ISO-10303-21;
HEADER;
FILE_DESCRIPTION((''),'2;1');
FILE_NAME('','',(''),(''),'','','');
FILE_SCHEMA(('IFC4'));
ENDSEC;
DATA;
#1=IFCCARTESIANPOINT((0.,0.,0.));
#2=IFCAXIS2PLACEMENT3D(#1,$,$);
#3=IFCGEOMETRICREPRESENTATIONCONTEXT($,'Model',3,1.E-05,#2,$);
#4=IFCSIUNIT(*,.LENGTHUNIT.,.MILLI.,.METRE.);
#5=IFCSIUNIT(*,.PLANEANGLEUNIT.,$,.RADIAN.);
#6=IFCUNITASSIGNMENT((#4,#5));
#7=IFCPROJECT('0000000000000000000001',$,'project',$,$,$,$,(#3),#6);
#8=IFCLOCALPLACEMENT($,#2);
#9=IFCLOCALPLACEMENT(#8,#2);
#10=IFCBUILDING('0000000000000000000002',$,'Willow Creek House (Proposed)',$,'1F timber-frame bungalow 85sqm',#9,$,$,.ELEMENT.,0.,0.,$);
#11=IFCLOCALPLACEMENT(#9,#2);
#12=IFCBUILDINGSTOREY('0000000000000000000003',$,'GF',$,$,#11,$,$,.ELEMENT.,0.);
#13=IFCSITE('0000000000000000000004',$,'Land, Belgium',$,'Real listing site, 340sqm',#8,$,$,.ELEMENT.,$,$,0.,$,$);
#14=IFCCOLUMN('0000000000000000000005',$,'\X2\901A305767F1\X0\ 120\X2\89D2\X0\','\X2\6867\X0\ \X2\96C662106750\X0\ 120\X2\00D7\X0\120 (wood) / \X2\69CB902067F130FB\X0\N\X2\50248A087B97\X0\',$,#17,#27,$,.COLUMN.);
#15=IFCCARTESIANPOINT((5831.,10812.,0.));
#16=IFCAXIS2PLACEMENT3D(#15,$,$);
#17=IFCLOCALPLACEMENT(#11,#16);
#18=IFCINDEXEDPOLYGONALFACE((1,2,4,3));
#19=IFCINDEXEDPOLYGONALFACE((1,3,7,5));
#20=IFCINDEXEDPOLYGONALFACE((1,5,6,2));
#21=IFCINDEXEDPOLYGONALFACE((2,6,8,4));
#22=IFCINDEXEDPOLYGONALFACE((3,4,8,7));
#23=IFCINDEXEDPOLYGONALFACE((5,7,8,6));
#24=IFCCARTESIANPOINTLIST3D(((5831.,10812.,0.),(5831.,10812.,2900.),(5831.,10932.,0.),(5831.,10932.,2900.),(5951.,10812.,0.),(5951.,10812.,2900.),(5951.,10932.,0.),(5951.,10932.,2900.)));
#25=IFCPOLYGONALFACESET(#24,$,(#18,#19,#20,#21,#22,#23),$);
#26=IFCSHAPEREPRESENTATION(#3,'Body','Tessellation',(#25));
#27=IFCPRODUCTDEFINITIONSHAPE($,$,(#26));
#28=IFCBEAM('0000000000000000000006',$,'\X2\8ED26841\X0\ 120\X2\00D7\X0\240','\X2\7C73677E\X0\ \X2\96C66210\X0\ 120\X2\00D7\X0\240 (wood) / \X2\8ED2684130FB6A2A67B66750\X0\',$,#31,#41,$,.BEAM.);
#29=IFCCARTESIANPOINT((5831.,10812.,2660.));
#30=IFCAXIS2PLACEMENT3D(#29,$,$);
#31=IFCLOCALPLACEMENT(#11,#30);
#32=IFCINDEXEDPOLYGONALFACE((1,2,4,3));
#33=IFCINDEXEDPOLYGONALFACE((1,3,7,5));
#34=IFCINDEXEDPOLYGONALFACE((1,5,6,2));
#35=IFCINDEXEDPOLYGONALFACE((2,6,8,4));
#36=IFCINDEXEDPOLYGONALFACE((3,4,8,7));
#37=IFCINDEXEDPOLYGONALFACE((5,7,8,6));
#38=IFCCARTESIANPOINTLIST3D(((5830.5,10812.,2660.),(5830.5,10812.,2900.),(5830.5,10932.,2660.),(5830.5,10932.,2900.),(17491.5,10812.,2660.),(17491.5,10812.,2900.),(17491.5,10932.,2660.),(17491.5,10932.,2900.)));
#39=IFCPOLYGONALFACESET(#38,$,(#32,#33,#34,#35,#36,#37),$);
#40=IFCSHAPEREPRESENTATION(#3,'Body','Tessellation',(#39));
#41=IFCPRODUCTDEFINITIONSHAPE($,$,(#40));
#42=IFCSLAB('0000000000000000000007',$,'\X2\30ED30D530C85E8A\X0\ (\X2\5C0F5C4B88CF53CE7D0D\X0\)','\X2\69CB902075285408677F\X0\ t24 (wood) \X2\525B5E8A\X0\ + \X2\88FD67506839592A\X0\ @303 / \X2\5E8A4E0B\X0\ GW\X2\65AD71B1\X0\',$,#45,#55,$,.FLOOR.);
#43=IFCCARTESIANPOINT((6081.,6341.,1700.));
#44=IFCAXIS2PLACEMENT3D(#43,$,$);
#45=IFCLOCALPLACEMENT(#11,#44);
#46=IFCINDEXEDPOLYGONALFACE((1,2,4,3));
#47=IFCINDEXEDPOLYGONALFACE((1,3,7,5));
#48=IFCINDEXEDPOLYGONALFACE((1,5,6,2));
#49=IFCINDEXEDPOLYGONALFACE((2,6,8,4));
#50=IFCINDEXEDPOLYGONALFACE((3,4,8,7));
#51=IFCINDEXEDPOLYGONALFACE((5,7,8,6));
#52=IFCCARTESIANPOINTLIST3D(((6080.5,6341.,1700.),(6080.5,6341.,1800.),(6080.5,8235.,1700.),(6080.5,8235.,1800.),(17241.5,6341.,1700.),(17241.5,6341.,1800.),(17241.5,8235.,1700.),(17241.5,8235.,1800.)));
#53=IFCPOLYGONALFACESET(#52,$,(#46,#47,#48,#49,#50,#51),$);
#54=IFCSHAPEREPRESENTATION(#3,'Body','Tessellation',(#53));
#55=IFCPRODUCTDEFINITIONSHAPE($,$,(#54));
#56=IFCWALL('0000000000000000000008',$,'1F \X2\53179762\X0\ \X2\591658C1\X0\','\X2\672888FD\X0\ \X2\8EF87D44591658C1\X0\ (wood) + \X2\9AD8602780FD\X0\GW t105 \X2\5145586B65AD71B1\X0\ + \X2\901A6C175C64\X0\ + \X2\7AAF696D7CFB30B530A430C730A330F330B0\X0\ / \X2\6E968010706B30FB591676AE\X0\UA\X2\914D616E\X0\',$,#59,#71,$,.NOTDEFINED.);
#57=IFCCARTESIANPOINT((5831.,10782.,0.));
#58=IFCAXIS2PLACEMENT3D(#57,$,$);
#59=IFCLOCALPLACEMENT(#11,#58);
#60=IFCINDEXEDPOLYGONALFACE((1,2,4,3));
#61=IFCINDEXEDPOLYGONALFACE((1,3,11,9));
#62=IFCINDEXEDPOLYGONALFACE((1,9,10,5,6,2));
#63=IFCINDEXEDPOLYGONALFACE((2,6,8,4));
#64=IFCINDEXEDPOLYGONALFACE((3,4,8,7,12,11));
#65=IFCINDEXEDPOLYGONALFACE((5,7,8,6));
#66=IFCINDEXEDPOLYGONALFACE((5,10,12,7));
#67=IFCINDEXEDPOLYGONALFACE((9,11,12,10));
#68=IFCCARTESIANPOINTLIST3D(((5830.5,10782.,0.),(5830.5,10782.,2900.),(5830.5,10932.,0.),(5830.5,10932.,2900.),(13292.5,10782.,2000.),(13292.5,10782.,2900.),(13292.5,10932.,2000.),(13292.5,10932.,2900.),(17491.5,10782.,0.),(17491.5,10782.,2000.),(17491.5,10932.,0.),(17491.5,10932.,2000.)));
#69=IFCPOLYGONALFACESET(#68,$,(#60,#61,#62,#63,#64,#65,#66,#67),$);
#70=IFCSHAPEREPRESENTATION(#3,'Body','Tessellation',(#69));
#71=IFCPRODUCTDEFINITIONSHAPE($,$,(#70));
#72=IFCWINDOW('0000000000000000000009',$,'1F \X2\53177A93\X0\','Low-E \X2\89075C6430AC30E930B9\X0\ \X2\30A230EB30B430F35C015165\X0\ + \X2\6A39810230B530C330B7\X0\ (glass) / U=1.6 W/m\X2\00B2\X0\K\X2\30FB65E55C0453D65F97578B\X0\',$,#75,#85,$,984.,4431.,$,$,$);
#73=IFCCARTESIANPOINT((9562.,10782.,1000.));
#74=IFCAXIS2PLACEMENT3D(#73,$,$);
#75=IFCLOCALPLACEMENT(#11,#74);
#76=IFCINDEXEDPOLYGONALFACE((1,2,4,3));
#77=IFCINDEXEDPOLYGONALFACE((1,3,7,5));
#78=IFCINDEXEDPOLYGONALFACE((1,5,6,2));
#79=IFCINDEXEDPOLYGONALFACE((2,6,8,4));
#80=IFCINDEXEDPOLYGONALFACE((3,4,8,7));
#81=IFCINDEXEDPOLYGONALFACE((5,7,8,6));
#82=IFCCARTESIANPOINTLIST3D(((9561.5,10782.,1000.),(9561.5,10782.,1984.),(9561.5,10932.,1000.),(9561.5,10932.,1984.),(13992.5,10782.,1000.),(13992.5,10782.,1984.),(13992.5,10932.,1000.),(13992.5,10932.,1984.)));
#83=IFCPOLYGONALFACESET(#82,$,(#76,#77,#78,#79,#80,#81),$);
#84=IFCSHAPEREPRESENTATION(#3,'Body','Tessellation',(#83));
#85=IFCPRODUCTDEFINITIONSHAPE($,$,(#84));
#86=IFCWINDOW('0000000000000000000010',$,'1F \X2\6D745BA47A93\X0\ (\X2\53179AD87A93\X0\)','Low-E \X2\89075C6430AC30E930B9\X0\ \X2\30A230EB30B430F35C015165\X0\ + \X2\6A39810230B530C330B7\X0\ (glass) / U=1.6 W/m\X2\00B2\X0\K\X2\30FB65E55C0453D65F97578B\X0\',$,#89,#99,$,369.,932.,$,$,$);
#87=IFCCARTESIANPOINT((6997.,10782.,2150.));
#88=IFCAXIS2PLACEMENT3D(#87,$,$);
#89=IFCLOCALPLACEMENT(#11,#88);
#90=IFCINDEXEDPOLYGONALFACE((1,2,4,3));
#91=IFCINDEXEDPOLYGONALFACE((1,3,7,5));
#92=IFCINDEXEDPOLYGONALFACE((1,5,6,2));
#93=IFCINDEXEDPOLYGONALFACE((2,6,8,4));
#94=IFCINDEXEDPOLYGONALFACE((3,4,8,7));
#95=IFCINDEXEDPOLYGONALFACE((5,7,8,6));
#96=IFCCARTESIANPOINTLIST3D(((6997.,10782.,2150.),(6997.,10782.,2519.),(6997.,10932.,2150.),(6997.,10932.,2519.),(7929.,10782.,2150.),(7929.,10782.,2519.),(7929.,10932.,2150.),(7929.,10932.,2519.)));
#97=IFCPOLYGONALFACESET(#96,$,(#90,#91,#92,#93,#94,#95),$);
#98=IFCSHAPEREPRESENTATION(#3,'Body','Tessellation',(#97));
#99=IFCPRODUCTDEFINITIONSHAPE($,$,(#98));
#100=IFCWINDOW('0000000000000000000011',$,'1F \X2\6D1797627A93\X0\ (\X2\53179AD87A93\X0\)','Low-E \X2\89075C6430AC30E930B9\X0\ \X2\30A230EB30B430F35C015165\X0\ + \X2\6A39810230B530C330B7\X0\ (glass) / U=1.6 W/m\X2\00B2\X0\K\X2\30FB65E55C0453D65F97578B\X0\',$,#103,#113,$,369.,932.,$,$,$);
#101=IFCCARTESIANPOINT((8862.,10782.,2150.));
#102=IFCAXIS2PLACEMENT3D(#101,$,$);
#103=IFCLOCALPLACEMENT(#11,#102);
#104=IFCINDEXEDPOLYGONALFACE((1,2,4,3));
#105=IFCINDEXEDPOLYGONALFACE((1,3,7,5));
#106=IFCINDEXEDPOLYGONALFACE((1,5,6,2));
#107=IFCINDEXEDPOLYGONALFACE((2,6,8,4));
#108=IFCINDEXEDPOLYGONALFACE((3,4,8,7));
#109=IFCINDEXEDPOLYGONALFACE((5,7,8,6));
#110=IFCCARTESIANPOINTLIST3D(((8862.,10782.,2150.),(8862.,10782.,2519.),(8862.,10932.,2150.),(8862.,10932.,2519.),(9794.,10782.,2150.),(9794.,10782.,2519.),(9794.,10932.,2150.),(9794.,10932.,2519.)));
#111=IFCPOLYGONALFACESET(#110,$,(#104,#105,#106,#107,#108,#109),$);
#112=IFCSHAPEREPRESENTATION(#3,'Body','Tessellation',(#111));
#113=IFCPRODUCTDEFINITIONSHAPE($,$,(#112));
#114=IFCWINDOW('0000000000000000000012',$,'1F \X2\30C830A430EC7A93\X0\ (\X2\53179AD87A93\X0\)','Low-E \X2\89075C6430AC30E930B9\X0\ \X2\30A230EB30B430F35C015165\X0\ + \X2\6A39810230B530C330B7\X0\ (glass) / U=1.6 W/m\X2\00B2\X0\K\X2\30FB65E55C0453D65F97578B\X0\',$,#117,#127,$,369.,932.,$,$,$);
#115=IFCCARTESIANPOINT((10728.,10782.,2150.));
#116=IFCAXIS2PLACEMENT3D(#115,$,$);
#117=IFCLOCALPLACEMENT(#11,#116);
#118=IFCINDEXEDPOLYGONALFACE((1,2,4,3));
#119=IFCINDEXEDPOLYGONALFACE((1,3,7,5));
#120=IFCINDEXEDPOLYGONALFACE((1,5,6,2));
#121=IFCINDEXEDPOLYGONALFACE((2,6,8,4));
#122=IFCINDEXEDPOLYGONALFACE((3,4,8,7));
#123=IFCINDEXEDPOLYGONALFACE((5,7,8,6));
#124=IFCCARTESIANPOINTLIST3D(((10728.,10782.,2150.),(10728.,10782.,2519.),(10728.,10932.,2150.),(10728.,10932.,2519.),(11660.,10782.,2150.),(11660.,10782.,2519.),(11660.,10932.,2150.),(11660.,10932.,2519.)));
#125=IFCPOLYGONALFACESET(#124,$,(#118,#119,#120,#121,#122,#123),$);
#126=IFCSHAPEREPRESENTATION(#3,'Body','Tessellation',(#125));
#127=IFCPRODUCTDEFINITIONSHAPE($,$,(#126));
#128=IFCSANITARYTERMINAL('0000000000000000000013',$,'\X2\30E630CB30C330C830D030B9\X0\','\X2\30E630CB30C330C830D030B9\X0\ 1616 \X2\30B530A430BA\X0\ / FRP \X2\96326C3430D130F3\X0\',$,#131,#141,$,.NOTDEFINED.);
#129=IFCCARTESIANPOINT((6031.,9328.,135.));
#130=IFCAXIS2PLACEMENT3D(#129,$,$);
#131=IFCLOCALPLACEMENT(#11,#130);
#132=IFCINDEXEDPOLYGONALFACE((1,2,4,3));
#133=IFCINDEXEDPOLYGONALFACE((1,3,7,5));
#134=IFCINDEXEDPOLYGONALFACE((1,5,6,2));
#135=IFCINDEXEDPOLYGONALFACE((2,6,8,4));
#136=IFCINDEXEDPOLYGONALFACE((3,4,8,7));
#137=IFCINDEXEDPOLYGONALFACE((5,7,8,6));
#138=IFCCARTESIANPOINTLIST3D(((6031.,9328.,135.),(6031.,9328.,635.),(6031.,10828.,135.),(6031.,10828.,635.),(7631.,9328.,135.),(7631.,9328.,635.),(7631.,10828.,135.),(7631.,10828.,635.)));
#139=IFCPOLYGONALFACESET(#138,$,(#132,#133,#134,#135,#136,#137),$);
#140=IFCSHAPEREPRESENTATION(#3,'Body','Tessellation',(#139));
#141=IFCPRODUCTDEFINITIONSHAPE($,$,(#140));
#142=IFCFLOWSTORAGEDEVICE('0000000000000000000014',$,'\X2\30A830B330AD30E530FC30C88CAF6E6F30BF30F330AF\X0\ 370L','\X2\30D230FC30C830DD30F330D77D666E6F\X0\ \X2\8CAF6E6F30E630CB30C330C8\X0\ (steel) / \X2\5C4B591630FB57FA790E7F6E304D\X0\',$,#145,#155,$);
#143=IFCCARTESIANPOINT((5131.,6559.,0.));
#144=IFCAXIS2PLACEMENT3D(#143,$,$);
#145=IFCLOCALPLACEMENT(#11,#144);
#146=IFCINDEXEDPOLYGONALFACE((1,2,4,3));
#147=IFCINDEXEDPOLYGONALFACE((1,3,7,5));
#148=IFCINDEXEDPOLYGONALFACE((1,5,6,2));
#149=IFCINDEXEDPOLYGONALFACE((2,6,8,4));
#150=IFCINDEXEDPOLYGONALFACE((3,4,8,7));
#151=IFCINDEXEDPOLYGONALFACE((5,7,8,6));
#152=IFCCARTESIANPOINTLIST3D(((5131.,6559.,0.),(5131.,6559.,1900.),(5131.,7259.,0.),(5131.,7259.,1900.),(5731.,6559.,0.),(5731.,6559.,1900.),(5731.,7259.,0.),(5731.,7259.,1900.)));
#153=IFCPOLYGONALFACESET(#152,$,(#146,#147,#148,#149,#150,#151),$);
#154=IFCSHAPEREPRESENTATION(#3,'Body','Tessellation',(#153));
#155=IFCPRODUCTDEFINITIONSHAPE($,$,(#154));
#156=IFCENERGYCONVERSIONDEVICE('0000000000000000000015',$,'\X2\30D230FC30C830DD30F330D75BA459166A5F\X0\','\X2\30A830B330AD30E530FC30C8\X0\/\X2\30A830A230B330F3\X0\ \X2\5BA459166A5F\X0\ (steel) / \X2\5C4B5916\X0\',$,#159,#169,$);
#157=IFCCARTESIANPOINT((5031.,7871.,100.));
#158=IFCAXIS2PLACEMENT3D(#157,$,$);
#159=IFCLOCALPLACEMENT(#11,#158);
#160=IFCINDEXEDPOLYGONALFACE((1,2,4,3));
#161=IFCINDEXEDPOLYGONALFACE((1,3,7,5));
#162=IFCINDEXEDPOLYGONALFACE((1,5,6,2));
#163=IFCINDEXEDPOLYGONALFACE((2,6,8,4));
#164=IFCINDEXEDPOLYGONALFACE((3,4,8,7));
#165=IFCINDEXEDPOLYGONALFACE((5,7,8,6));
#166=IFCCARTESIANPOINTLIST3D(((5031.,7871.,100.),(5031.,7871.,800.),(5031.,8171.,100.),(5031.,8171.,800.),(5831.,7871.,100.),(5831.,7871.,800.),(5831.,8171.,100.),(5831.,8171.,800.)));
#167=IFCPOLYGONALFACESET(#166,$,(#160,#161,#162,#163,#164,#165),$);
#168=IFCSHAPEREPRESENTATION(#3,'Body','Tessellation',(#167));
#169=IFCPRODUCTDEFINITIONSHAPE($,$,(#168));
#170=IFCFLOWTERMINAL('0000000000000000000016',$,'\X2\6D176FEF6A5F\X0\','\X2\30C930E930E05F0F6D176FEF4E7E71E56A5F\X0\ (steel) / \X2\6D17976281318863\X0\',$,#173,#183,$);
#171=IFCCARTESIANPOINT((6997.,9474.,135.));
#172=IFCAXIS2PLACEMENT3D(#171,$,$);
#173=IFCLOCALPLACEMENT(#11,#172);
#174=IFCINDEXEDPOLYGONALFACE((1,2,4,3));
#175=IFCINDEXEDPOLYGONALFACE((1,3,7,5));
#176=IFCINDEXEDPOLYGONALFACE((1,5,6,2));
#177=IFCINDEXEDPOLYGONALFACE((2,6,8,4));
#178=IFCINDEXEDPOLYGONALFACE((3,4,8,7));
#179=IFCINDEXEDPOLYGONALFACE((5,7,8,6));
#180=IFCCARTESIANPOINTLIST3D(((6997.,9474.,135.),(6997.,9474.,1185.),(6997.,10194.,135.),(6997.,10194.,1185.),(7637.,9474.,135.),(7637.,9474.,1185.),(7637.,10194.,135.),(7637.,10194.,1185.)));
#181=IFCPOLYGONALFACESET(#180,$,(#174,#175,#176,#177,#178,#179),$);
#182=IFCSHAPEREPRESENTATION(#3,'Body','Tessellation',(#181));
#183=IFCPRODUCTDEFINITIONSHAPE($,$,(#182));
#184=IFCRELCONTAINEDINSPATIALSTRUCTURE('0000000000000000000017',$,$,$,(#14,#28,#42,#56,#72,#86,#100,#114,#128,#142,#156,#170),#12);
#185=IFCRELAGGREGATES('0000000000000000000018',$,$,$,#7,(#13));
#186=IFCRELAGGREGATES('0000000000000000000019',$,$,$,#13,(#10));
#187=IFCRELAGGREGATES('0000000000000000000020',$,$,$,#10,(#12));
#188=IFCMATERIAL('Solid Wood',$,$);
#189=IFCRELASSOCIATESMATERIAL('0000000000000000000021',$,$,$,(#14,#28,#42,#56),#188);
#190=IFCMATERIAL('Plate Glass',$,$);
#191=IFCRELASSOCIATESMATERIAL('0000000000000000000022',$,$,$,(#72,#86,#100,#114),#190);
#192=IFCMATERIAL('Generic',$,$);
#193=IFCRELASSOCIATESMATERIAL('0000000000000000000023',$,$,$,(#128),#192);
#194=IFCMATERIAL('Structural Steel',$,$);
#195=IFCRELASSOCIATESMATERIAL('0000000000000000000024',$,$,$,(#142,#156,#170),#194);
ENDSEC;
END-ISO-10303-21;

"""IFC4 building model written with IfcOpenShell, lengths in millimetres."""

from ifc_helpers import new_model, si_unit, frame, frame_2d, origin, place, context, project, spatial, rectangle, extrude, material, element, fill, save


model = new_model("IFC4")

# Units and contexts
model_context = context("Model", 3, precision=1e-05, world=origin())
ifc_project = project(units=[si_unit("LENGTHUNIT", "METRE", prefix="MILLI"), si_unit("PLANEANGLEUNIT", "RADIAN")], contexts=[model_context])

# Site, building, storey
site_placement = place(None, origin())
site = spatial("IfcSite", under=ifc_project, at=site_placement, Name="Land, Belgium", ObjectType="Real listing site, 340sqm", CompositionType="ELEMENT", RefElevation=0.0)
building_placement = place(site_placement, origin())
building = spatial("IfcBuilding", under=site, at=building_placement, Name="Willow Creek House (Proposed)", ObjectType="1F timber-frame bungalow 85sqm", CompositionType="ELEMENT", ElevationOfRefHeight=0.0, ElevationOfTerrain=0.0)
storey_placement = place(building_placement, origin())
storey = spatial("IfcBuildingStorey", under=building, at=storey_placement, Name="GF", CompositionType="ELEMENT", Elevation=0.0)

# Column
ifc_material_1 = material(Name="Solid Wood")
column_1_placement = place(storey_placement, frame((5831.0, 10812.0, 0.0)))
element("IfcColumn", 1, at=column_1_placement, inside=storey, material=ifc_material_1, Name="通し柱 120角", Description="桧 集成材 120×120 (wood) / 構造柱・N値計算", PredefinedType="COLUMN", context=model_context, shape_type="SweptSolid", body=[
    extrude(rectangle(XDim=120.0, YDim=120.0, at=frame_2d((60.0, 60.0))), frame((5831.0, 10812.0, 0.0)), (0.0, 0.0, 1.0), 2900.0),
])

# Beam
beam_1_placement = place(storey_placement, frame((5831.0, 10812.0, 2660.0)))
element("IfcBeam", 2, at=beam_1_placement, inside=storey, material=ifc_material_1, Name="軒桁 120×240", Description="米松 集成 120×240 (wood) / 軒桁・横架材", PredefinedType="BEAM", context=model_context, shape_type="SweptSolid", body=[
    extrude(rectangle(XDim=11661.0, YDim=120.0, at=frame_2d((5830.0, 60.0))), frame((5831.0, 10812.0, 2660.0)), (0.0, 0.0, 1.0), 240.0),
])

# Slab
slab_placement = place(storey_placement, frame((6081.0, 6341.0, 1700.0)))
element("IfcSlab", 3, at=slab_placement, inside=storey, material=ifc_material_1, Name="ロフト床 (小屋裏収納)", Description="構造用合板 t24 (wood) 剛床 + 製材根太 @303 / 床下 GW断熱", PredefinedType="FLOOR", context=model_context, shape_type="SweptSolid", body=[
    extrude(rectangle(XDim=11161.0, YDim=1894.0, at=frame_2d((5580.0, 947.0))), frame((6081.0, 6341.0, 1700.0)), (0.0, 0.0, 1.0), 100.0),
])

# Wall, openings, windows
wall_1_placement = place(storey_placement, frame((5831.0, 10782.0, 0.0)))
wall_1 = element("IfcWall", 4, at=wall_1_placement, inside=storey, material=ifc_material_1, Name="1F 北面 外壁", Description="木製 軸組外壁 (wood) + 高性能GW t105 充填断熱 + 通気層 + 窯業系サイディング / 準耐火・外皮UA配慮", PredefinedType="NOTDEFINED", context=model_context, shape_type="SweptSolid", body=[
    extrude(rectangle(XDim=11661.0, YDim=150.0, at=frame_2d((5830.0, 75.0))), frame((5831.0, 10782.0, 0.0)), (0.0, 0.0, 1.0), 2900.0),
])
opening_1_placement = place(storey_placement, frame((9562.0, 10782.0, 1000.0)))
opening_1 = element("IfcOpeningElement", 5, at=opening_1_placement, cuts=wall_1, PredefinedType="NOTDEFINED", context=model_context, shape_type="SweptSolid", body=[
    extrude(rectangle(XDim=4431.0, YDim=150.0, at=frame_2d((2215.0, 75.0))), frame((9562.0, 10782.0, 1000.0)), (0.0, 0.0, 1.0), 984.0),
])
opening_2_placement = place(storey_placement, frame((6997.0, 10782.0, 2150.0)))
opening_2 = element("IfcOpeningElement", 6, at=opening_2_placement, cuts=wall_1, PredefinedType="NOTDEFINED", context=model_context, shape_type="SweptSolid", body=[
    extrude(rectangle(XDim=932.0, YDim=150.0, at=frame_2d((466.0, 75.0))), frame((6997.0, 10782.0, 2150.0)), (0.0, 0.0, 1.0), 369.0),
])
opening_3_placement = place(storey_placement, frame((8862.0, 10782.0, 2150.0)))
opening_3 = element("IfcOpeningElement", 7, at=opening_3_placement, cuts=wall_1, PredefinedType="NOTDEFINED", context=model_context, shape_type="SweptSolid", body=[
    extrude(rectangle(XDim=932.0, YDim=150.0, at=frame_2d((466.0, 75.0))), frame((8862.0, 10782.0, 2150.0)), (0.0, 0.0, 1.0), 369.0),
])
opening_4_placement = place(storey_placement, frame((10728.0, 10782.0, 2150.0)))
opening_4 = element("IfcOpeningElement", 8, at=opening_4_placement, cuts=wall_1, PredefinedType="NOTDEFINED", context=model_context, shape_type="SweptSolid", body=[
    extrude(rectangle(XDim=932.0, YDim=150.0, at=frame_2d((466.0, 75.0))), frame((10728.0, 10782.0, 2150.0)), (0.0, 0.0, 1.0), 369.0),
])
ifc_material_2 = material(Name="Plate Glass")
window_1_placement = place(storey_placement, frame((9562.0, 10782.0, 1000.0)))
window_1 = element("IfcWindow", 9, at=window_1_placement, inside=storey, material=ifc_material_2, Name="1F 北窓", Description="Low-E 複層ガラス アルゴン封入 + 樹脂サッシ (glass) / U=1.6 W/m²K・日射取得型", OverallHeight=984.0, OverallWidth=4431.0, context=model_context, shape_type="SweptSolid", body=[
    extrude(rectangle(XDim=4431.0, YDim=150.0, at=frame_2d((2215.0, 75.0))), frame((9562.0, 10782.0, 1000.0)), (0.0, 0.0, 1.0), 984.0),
])
fill(opening_1, window_1)
window_2_placement = place(storey_placement, frame((6997.0, 10782.0, 2150.0)))
window_2 = element("IfcWindow", 10, at=window_2_placement, inside=storey, material=ifc_material_2, Name="1F 浴室窓 (北高窓)", Description="Low-E 複層ガラス アルゴン封入 + 樹脂サッシ (glass) / U=1.6 W/m²K・日射取得型", OverallHeight=369.0, OverallWidth=932.0, context=model_context, shape_type="SweptSolid", body=[
    extrude(rectangle(XDim=932.0, YDim=150.0, at=frame_2d((466.0, 75.0))), frame((6997.0, 10782.0, 2150.0)), (0.0, 0.0, 1.0), 369.0),
])
fill(opening_2, window_2)
window_3_placement = place(storey_placement, frame((8862.0, 10782.0, 2150.0)))
window_3 = element("IfcWindow", 11, at=window_3_placement, inside=storey, material=ifc_material_2, Name="1F 洗面窓 (北高窓)", Description="Low-E 複層ガラス アルゴン封入 + 樹脂サッシ (glass) / U=1.6 W/m²K・日射取得型", OverallHeight=369.0, OverallWidth=932.0, context=model_context, shape_type="SweptSolid", body=[
    extrude(rectangle(XDim=932.0, YDim=150.0, at=frame_2d((466.0, 75.0))), frame((8862.0, 10782.0, 2150.0)), (0.0, 0.0, 1.0), 369.0),
])
fill(opening_3, window_3)
window_4_placement = place(storey_placement, frame((10728.0, 10782.0, 2150.0)))
window_4 = element("IfcWindow", 12, at=window_4_placement, inside=storey, material=ifc_material_2, Name="1F トイレ窓 (北高窓)", Description="Low-E 複層ガラス アルゴン封入 + 樹脂サッシ (glass) / U=1.6 W/m²K・日射取得型", OverallHeight=369.0, OverallWidth=932.0, context=model_context, shape_type="SweptSolid", body=[
    extrude(rectangle(XDim=932.0, YDim=150.0, at=frame_2d((466.0, 75.0))), frame((10728.0, 10782.0, 2150.0)), (0.0, 0.0, 1.0), 369.0),
])
fill(opening_4, window_4)

# Sanitary terminal
ifc_material_3 = material(Name="Generic")
sanitary_terminal_placement = place(storey_placement, frame((6031.0, 9328.0, 135.0)))
element("IfcSanitaryTerminal", 13, at=sanitary_terminal_placement, inside=storey, material=ifc_material_3, Name="ユニットバス", Description="ユニットバス 1616 サイズ / FRP 防水パン", PredefinedType="NOTDEFINED", context=model_context, shape_type="SweptSolid", body=[
    extrude(rectangle(XDim=1600.0, YDim=1500.0, at=frame_2d((800.0, 750.0))), frame((6031.0, 9328.0, 135.0)), (0.0, 0.0, 1.0), 500.0),
])

# Flow storage device
ifc_material_4 = material(Name="Structural Steel")
flow_storage_device_placement = place(storey_placement, frame((5131.0, 6559.0, 0.0)))
element("IfcFlowStorageDevice", 14, at=flow_storage_device_placement, inside=storey, material=ifc_material_4, Name="エコキュート貯湯タンク 370L", Description="ヒートポンプ給湯 貯湯ユニット (steel) / 屋外・基礎置き", context=model_context, shape_type="SweptSolid", body=[
    extrude(rectangle(XDim=600.0, YDim=700.0, at=frame_2d((300.0, 350.0))), frame((5131.0, 6559.0, 0.0)), (0.0, 0.0, 1.0), 1900.0),
])

# Energy conversion device
energy_conversion_device_placement = place(storey_placement, frame((5031.0, 7871.0, 100.0)))
element("IfcEnergyConversionDevice", 15, at=energy_conversion_device_placement, inside=storey, material=ifc_material_4, Name="ヒートポンプ室外機", Description="エコキュート/エアコン 室外機 (steel) / 屋外", context=model_context, shape_type="SweptSolid", body=[
    extrude(rectangle(XDim=800.0, YDim=300.0, at=frame_2d((400.0, 150.0))), frame((5031.0, 7871.0, 100.0)), (0.0, 0.0, 1.0), 700.0),
])

# Flow terminal
flow_terminal_placement = place(storey_placement, frame((6997.0, 9474.0, 135.0)))
element("IfcFlowTerminal", 16, at=flow_terminal_placement, inside=storey, material=ifc_material_4, Name="洗濯機", Description="ドラム式洗濯乾燥機 (steel) / 洗面脱衣", context=model_context, shape_type="SweptSolid", body=[
    extrude(rectangle(XDim=640.0, YDim=720.0, at=frame_2d((320.0, 360.0))), frame((6997.0, 9474.0, 135.0)), (0.0, 0.0, 1.0), 1050.0),
])

save(model, "model.ifc")
